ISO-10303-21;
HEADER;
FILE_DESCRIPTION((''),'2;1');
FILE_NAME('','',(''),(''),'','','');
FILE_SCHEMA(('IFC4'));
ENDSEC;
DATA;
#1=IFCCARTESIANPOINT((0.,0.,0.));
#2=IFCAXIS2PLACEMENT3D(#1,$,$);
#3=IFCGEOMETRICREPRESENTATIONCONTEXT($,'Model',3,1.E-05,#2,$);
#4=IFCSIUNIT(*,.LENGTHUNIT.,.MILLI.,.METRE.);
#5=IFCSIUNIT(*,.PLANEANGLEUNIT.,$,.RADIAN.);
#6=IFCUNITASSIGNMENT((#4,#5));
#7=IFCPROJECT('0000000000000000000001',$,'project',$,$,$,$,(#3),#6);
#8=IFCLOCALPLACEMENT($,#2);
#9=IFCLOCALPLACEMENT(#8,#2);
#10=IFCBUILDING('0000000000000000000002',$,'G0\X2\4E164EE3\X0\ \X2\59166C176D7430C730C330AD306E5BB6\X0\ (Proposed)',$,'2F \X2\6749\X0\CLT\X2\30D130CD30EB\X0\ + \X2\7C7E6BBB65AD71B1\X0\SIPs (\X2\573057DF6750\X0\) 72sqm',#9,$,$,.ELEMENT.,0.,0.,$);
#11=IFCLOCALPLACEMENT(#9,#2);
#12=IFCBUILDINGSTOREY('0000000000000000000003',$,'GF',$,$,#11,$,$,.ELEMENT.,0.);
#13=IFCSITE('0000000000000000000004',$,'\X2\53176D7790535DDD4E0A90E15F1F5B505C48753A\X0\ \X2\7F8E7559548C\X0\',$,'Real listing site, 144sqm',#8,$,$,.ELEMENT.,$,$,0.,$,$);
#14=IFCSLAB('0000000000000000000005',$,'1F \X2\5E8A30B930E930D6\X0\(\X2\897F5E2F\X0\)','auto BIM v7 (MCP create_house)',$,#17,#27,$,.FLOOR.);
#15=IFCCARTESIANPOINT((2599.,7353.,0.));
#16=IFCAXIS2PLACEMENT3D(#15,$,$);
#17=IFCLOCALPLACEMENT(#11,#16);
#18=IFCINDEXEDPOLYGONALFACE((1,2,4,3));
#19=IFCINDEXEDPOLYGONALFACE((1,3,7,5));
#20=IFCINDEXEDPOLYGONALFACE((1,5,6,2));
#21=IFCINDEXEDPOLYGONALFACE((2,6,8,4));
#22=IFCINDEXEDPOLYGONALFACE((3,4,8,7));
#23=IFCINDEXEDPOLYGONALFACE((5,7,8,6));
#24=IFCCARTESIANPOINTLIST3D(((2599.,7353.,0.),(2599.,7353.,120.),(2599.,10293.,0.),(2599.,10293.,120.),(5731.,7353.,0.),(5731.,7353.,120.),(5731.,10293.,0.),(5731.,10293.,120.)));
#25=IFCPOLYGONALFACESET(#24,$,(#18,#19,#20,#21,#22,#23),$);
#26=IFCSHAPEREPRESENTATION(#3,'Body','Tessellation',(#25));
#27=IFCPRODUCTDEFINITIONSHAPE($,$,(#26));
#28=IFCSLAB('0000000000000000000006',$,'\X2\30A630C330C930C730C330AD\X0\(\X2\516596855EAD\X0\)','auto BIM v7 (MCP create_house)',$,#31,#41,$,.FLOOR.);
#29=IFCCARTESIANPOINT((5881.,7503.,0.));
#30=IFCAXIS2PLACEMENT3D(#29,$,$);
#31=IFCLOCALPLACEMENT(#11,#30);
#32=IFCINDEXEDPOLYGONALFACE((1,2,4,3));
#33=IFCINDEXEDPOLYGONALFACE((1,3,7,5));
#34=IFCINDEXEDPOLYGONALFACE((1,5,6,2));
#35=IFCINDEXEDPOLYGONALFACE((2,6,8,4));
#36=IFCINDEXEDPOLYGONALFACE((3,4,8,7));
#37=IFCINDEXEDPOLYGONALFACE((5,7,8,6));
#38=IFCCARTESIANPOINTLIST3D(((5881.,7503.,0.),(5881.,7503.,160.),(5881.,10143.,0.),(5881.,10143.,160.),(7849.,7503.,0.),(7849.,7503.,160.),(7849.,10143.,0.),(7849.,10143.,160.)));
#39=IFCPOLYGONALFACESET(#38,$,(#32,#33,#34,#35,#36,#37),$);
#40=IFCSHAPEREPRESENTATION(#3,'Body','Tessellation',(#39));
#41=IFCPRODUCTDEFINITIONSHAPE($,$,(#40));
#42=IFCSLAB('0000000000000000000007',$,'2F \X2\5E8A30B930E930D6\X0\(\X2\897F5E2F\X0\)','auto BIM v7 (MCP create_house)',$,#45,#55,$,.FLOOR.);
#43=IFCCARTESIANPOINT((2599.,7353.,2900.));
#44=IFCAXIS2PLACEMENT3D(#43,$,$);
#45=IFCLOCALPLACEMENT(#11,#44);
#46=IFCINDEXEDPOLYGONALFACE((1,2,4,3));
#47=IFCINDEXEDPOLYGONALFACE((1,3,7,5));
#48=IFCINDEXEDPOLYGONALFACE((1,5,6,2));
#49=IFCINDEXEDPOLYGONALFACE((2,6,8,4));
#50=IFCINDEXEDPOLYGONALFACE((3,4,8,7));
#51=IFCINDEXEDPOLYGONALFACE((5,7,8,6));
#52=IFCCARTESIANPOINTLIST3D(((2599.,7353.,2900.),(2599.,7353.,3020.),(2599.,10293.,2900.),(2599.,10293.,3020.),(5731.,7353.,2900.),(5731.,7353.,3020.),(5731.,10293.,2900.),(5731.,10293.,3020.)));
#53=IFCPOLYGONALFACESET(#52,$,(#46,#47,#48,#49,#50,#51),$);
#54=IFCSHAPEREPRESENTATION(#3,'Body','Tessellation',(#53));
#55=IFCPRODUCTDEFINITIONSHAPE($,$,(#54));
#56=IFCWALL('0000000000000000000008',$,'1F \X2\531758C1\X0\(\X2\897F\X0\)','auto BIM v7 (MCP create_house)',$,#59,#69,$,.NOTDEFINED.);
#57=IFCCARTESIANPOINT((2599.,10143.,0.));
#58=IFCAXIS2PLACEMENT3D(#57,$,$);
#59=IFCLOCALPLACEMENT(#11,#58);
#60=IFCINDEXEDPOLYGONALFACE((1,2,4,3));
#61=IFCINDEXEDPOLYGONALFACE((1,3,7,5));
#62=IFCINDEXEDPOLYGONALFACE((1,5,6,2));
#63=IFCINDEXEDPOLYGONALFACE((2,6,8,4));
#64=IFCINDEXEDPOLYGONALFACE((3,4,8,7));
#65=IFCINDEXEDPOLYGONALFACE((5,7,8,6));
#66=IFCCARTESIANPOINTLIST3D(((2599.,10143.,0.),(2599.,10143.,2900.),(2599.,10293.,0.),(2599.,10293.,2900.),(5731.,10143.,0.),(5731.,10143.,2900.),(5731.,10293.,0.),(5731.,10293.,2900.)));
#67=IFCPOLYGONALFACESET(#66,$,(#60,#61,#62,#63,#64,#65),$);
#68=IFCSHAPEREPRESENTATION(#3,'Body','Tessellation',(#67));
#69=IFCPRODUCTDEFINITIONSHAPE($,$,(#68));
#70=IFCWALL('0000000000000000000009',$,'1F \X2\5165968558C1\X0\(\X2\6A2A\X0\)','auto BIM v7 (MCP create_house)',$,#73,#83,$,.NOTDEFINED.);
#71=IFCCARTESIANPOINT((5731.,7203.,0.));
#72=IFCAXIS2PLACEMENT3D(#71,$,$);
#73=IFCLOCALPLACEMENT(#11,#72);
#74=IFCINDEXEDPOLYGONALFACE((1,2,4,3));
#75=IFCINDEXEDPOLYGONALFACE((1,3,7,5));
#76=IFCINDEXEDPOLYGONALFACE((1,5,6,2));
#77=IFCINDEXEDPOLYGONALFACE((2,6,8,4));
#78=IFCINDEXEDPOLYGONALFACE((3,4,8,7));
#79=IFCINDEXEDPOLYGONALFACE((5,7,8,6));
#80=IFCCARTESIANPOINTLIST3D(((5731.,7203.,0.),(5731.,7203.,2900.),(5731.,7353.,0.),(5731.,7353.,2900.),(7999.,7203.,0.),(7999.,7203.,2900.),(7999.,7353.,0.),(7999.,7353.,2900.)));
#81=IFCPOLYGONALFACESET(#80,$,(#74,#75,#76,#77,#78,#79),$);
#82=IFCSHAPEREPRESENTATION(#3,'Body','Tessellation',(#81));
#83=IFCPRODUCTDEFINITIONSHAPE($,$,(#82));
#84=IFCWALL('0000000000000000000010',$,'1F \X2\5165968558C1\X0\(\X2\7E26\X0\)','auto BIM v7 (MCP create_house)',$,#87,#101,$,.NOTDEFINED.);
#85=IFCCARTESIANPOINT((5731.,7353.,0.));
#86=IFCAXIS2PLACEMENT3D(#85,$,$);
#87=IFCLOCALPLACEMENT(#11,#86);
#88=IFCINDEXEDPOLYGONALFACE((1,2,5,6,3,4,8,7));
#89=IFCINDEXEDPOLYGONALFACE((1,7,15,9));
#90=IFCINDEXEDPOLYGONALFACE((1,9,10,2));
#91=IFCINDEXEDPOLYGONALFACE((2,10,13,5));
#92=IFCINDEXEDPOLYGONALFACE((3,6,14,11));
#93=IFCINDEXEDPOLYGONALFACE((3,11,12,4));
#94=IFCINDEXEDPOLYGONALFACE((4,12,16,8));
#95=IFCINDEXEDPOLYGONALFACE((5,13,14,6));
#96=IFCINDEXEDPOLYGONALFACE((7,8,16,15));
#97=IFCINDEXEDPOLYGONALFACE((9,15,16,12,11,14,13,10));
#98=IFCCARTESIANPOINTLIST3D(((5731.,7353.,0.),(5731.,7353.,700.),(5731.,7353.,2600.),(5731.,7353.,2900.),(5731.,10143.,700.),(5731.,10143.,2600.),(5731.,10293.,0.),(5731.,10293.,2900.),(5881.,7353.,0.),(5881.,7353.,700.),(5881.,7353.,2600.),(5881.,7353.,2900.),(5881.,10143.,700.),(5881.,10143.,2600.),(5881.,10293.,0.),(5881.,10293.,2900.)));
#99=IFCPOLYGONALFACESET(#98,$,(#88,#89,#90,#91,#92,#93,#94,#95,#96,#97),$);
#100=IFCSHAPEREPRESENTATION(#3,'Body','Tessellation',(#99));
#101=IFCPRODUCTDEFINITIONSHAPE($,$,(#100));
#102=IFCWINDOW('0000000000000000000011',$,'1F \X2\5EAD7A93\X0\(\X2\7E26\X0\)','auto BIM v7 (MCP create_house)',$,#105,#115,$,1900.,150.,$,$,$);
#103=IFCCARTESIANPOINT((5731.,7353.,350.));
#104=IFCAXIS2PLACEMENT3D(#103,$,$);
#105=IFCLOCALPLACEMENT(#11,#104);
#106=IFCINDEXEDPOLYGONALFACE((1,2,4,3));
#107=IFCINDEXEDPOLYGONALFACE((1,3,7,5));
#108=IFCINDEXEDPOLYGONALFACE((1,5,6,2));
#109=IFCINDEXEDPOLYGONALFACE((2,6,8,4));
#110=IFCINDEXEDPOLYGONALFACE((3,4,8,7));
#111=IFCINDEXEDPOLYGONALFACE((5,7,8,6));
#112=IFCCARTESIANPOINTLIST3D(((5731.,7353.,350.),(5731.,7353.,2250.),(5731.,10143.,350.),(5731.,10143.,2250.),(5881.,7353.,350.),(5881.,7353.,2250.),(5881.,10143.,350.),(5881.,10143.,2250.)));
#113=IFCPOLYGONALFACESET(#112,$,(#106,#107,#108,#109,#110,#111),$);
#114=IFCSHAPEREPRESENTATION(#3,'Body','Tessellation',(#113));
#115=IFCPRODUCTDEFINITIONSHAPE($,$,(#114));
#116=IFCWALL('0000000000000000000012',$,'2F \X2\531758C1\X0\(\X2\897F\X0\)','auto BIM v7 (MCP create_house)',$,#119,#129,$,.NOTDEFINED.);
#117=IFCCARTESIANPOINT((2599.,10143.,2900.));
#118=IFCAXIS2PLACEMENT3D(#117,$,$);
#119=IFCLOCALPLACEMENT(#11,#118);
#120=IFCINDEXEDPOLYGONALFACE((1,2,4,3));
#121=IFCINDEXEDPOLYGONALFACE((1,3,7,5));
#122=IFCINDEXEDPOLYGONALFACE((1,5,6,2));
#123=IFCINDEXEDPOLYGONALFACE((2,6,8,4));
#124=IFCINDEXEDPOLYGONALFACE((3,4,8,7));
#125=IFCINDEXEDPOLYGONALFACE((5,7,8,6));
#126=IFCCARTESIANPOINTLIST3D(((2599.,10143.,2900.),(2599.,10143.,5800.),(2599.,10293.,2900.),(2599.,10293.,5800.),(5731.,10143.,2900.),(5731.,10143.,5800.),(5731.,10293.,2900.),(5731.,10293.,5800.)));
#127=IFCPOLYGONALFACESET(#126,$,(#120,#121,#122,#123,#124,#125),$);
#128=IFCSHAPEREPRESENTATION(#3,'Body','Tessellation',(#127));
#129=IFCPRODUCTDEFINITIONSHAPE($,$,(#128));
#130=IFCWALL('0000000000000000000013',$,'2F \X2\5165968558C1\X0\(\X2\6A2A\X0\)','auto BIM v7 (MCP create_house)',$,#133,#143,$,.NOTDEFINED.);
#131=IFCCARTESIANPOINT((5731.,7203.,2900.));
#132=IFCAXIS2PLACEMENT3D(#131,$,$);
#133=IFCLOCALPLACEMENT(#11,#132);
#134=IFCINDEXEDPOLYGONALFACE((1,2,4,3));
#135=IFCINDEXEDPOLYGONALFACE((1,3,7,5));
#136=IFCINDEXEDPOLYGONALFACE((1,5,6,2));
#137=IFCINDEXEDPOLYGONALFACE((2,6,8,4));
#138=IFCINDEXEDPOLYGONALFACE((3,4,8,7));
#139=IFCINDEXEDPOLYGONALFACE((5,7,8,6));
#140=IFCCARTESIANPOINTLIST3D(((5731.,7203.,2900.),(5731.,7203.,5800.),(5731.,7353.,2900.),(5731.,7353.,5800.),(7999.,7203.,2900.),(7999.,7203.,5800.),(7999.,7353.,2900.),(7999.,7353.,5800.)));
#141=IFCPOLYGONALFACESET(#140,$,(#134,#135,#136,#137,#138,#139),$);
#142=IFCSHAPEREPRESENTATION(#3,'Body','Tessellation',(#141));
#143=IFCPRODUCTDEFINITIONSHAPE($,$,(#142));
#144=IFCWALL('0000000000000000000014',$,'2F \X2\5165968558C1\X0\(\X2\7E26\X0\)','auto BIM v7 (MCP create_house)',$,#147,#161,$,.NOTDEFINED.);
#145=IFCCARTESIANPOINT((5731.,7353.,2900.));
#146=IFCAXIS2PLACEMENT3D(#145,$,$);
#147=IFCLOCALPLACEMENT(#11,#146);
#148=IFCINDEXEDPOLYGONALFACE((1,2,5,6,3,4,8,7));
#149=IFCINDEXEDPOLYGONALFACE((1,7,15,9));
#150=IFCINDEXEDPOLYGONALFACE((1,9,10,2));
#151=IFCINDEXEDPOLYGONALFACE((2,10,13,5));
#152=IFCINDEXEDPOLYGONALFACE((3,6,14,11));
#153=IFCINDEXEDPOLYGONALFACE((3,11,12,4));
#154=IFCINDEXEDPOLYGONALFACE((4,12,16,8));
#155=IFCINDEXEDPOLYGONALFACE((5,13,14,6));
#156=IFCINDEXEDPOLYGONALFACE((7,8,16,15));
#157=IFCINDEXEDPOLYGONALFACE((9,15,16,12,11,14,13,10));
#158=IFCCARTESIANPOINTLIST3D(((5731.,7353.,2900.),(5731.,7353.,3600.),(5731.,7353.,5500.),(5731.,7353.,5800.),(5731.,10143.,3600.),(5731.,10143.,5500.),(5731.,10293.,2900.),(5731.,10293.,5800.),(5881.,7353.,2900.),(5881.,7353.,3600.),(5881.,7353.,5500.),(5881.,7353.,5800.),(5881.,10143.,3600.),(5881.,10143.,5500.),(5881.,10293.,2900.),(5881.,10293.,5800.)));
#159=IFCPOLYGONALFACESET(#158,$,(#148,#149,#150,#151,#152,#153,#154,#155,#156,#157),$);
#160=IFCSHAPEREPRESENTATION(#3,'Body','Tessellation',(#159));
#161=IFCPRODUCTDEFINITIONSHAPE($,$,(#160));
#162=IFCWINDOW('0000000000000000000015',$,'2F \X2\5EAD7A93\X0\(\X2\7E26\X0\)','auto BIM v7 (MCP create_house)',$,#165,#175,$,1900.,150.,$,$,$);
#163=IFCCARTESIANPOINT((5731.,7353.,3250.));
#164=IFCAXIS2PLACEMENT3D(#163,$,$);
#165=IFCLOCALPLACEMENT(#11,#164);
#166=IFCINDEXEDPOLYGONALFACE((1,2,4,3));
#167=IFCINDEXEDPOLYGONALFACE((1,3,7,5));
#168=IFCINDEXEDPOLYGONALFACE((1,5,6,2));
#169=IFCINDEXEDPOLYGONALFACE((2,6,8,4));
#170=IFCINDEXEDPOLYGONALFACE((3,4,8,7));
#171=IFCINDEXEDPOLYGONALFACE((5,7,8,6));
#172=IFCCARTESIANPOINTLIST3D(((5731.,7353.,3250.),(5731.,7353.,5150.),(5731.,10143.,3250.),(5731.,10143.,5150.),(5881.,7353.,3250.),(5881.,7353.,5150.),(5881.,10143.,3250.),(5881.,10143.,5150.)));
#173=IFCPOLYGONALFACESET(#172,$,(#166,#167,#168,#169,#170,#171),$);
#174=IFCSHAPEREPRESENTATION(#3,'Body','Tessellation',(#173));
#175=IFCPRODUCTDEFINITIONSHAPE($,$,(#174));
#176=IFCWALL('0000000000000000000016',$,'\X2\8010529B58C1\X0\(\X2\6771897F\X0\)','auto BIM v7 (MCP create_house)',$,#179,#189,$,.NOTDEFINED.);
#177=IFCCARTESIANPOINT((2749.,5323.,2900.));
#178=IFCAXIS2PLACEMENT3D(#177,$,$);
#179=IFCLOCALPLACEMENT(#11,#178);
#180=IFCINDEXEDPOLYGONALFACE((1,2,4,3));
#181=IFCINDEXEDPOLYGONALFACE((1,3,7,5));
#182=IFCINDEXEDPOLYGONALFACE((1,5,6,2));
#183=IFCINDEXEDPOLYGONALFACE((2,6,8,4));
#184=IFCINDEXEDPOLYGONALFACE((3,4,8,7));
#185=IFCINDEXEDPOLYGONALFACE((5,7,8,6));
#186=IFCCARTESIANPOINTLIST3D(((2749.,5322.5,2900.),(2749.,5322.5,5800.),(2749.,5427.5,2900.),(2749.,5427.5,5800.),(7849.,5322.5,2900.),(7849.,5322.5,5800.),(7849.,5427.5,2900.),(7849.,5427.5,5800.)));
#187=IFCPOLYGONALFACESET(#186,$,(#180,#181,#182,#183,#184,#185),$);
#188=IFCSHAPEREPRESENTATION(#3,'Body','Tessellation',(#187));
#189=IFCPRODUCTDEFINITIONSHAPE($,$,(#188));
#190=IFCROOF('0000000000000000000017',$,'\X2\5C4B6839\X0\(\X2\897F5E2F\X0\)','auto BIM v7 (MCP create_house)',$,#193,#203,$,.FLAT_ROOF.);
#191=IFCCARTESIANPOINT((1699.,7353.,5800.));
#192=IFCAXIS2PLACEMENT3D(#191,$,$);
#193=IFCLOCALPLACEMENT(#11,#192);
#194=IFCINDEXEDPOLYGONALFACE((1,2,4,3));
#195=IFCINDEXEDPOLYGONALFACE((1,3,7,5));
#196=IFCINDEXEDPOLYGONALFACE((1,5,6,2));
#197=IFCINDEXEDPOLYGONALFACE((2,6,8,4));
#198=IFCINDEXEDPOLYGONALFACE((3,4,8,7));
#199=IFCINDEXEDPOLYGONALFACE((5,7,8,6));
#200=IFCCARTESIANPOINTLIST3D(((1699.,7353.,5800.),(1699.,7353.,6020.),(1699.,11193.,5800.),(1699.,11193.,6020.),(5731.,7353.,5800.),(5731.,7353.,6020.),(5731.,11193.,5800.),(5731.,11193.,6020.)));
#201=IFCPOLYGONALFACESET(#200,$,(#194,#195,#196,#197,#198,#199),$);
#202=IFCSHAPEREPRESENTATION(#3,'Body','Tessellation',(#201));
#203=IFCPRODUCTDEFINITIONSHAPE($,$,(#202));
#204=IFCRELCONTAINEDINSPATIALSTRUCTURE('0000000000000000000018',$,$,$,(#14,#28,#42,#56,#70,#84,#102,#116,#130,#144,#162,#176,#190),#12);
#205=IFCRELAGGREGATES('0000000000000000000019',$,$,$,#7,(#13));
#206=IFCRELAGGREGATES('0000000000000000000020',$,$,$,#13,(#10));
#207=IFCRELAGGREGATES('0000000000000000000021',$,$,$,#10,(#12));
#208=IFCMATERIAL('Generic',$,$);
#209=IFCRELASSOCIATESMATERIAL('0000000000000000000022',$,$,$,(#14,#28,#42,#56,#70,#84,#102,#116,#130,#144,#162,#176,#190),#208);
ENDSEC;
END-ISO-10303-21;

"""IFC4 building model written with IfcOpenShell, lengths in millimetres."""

from ifc_helpers import new_model, si_unit, frame, frame_2d, origin, place, context, project, spatial, rectangle, extrude, material, element, fill, save


model = new_model("IFC4")

# Units and contexts
model_context = context("Model", 3, precision=1e-05, world=origin())
ifc_project = project(units=[si_unit("LENGTHUNIT", "METRE", prefix="MILLI"), si_unit("PLANEANGLEUNIT", "RADIAN")], contexts=[model_context])

# Site, building, storey
site_placement = place(None, origin())
site = spatial("IfcSite", under=ifc_project, at=site_placement, Name="北海道川上郡弟子屈町 美留和", ObjectType="Real listing site, 144sqm", CompositionType="ELEMENT", RefElevation=0.0)
building_placement = place(site_placement, origin())
building = spatial("IfcBuilding", under=site, at=building_placement, Name="G0世代 外気浴デッキの家 (Proposed)", ObjectType="2F 杉CLTパネル + 籾殻断熱SIPs (地域材) 72sqm", CompositionType="ELEMENT", ElevationOfRefHeight=0.0, ElevationOfTerrain=0.0)
storey_placement = place(building_placement, origin())
storey = spatial("IfcBuildingStorey", under=building, at=storey_placement, Name="GF", CompositionType="ELEMENT", Elevation=0.0)

# Slabs
ifc_material = material(Name="Generic")
slab_1_placement = place(storey_placement, frame((2599.0, 7353.0, 0.0)))
element("IfcSlab", 1, at=slab_1_placement, inside=storey, material=ifc_material, Name="1F 床スラブ(西帯)", Description="auto BIM v7 (MCP create_house)", PredefinedType="FLOOR", context=model_context, shape_type="SweptSolid", body=[
    extrude(rectangle(XDim=3132.0, YDim=2940.0, at=frame_2d((1566.0, 1470.0))), frame((2599.0, 7353.0, 0.0)), (0.0, 0.0, 1.0), 120.0),
])
slab_2_placement = place(storey_placement, frame((5881.0, 7503.0, 0.0)))
element("IfcSlab", 2, at=slab_2_placement, inside=storey, material=ifc_material, Name="ウッドデッキ(入隅庭)", Description="auto BIM v7 (MCP create_house)", PredefinedType="FLOOR", context=model_context, shape_type="SweptSolid", body=[
    extrude(rectangle(XDim=1968.0, YDim=2640.0, at=frame_2d((984.0, 1320.0))), frame((5881.0, 7503.0, 0.0)), (0.0, 0.0, 1.0), 160.0),
])
slab_3_placement = place(storey_placement, frame((2599.0, 7353.0, 2900.0)))
element("IfcSlab", 3, at=slab_3_placement, inside=storey, material=ifc_material, Name="2F 床スラブ(西帯)", Description="auto BIM v7 (MCP create_house)", PredefinedType="FLOOR", context=model_context, shape_type="SweptSolid", body=[
    extrude(rectangle(XDim=3132.0, YDim=2940.0, at=frame_2d((1566.0, 1470.0))), frame((2599.0, 7353.0, 2900.0)), (0.0, 0.0, 1.0), 120.0),
])

# Walls
wall_1_placement = place(storey_placement, frame((2599.0, 10143.0, 0.0)))
element("IfcWall", 4, at=wall_1_placement, inside=storey, material=ifc_material, Name="1F 北壁(西)", Description="auto BIM v7 (MCP create_house)", PredefinedType="NOTDEFINED", context=model_context, shape_type="SweptSolid", body=[
    extrude(rectangle(XDim=3132.0, YDim=150.0, at=frame_2d((1566.0, 75.0))), frame((2599.0, 10143.0, 0.0)), (0.0, 0.0, 1.0), 2900.0),
])
wall_2_placement = place(storey_placement, frame((5731.0, 7203.0, 0.0)))
element("IfcWall", 5, at=wall_2_placement, inside=storey, material=ifc_material, Name="1F 入隅壁(横)", Description="auto BIM v7 (MCP create_house)", PredefinedType="NOTDEFINED", context=model_context, shape_type="SweptSolid", body=[
    extrude(rectangle(XDim=2268.0, YDim=150.0, at=frame_2d((1134.0, 75.0))), frame((5731.0, 7203.0, 0.0)), (0.0, 0.0, 1.0), 2900.0),
])

# Wall, opening, window
wall_3_placement = place(storey_placement, frame((5731.0, 7353.0, 0.0)))
wall_3 = element("IfcWall", 6, at=wall_3_placement, inside=storey, material=ifc_material, Name="1F 入隅壁(縦)", Description="auto BIM v7 (MCP create_house)", PredefinedType="NOTDEFINED", context=model_context, shape_type="SweptSolid", body=[
    extrude(rectangle(XDim=150.0, YDim=2940.0, at=frame_2d((75.0, 1470.0))), frame((5731.0, 7353.0, 0.0)), (0.0, 0.0, 1.0), 2900.0),
])
opening_1_placement = place(storey_placement, frame((5731.0, 7353.0, 350.0)))
opening_1 = element("IfcOpeningElement", 7, at=opening_1_placement, cuts=wall_3, PredefinedType="NOTDEFINED", context=model_context, shape_type="SweptSolid", body=[
    extrude(rectangle(XDim=150.0, YDim=2790.0, at=frame_2d((75.0, 1395.0))), frame((5731.0, 7353.0, 350.0)), (0.0, 0.0, 1.0), 1900.0),
])
window_1_placement = place(storey_placement, frame((5731.0, 7353.0, 350.0)))
window_1 = element("IfcWindow", 8, at=window_1_placement, inside=storey, material=ifc_material, Name="1F 庭窓(縦)", Description="auto BIM v7 (MCP create_house)", OverallHeight=1900.0, OverallWidth=150.0, context=model_context, shape_type="SweptSolid", body=[
    extrude(rectangle(XDim=150.0, YDim=2790.0, at=frame_2d((75.0, 1395.0))), frame((5731.0, 7353.0, 350.0)), (0.0, 0.0, 1.0), 1900.0),
])
fill(opening_1, window_1)

# Walls
wall_4_placement = place(storey_placement, frame((2599.0, 10143.0, 2900.0)))
element("IfcWall", 9, at=wall_4_placement, inside=storey, material=ifc_material, Name="2F 北壁(西)", Description="auto BIM v7 (MCP create_house)", PredefinedType="NOTDEFINED", context=model_context, shape_type="SweptSolid", body=[
    extrude(rectangle(XDim=3132.0, YDim=150.0, at=frame_2d((1566.0, 75.0))), frame((2599.0, 10143.0, 2900.0)), (0.0, 0.0, 1.0), 2900.0),
])
wall_5_placement = place(storey_placement, frame((5731.0, 7203.0, 2900.0)))
element("IfcWall", 10, at=wall_5_placement, inside=storey, material=ifc_material, Name="2F 入隅壁(横)", Description="auto BIM v7 (MCP create_house)", PredefinedType="NOTDEFINED", context=model_context, shape_type="SweptSolid", body=[
    extrude(rectangle(XDim=2268.0, YDim=150.0, at=frame_2d((1134.0, 75.0))), frame((5731.0, 7203.0, 2900.0)), (0.0, 0.0, 1.0), 2900.0),
])

# Wall, opening, window
wall_6_placement = place(storey_placement, frame((5731.0, 7353.0, 2900.0)))
wall_6 = element("IfcWall", 11, at=wall_6_placement, inside=storey, material=ifc_material, Name="2F 入隅壁(縦)", Description="auto BIM v7 (MCP create_house)", PredefinedType="NOTDEFINED", context=model_context, shape_type="SweptSolid", body=[
    extrude(rectangle(XDim=150.0, YDim=2940.0, at=frame_2d((75.0, 1470.0))), frame((5731.0, 7353.0, 2900.0)), (0.0, 0.0, 1.0), 2900.0),
])
opening_2_placement = place(storey_placement, frame((5731.0, 7353.0, 3250.0)))
opening_2 = element("IfcOpeningElement", 12, at=opening_2_placement, cuts=wall_6, PredefinedType="NOTDEFINED", context=model_context, shape_type="SweptSolid", body=[
    extrude(rectangle(XDim=150.0, YDim=2790.0, at=frame_2d((75.0, 1395.0))), frame((5731.0, 7353.0, 3250.0)), (0.0, 0.0, 1.0), 1900.0),
])
window_2_placement = place(storey_placement, frame((5731.0, 7353.0, 3250.0)))
window_2 = element("IfcWindow", 13, at=window_2_placement, inside=storey, material=ifc_material, Name="2F 庭窓(縦)", Description="auto BIM v7 (MCP create_house)", OverallHeight=1900.0, OverallWidth=150.0, context=model_context, shape_type="SweptSolid", body=[
    extrude(rectangle(XDim=150.0, YDim=2790.0, at=frame_2d((75.0, 1395.0))), frame((5731.0, 7353.0, 3250.0)), (0.0, 0.0, 1.0), 1900.0),
])
fill(opening_2, window_2)

# Wall
wall_7_placement = place(storey_placement, frame((2749.0, 5323.0, 2900.0)))
element("IfcWall", 14, at=wall_7_placement, inside=storey, material=ifc_material, Name="耐力壁(東西)", Description="auto BIM v7 (MCP create_house)", PredefinedType="NOTDEFINED", context=model_context, shape_type="SweptSolid", body=[
    extrude(rectangle(XDim=5100.0, YDim=105.0, at=frame_2d((2550.0, 52.0))), frame((2749.0, 5323.0, 2900.0)), (0.0, 0.0, 1.0), 2900.0),
])

# Roof
for number, where, name in (
    (15, (1699.0, 7353.0, 5800.0), "屋根(西帯)"),
):
    element("IfcRoof", number, at=place(storey_placement, frame(where)), inside=storey, material=ifc_material, Name=name, Description="auto BIM v7 (MCP create_house)", PredefinedType="FLAT_ROOF", context=model_context, shape_type="SweptSolid", body=[
        extrude(rectangle(XDim=4032.0, YDim=3840.0, at=frame_2d((2016.0, 1920.0))), frame((1699.0, 7353.0, 5800.0)), (0.0, 0.0, 1.0), 220.0),
    ])

save(model, "model.ifc")
